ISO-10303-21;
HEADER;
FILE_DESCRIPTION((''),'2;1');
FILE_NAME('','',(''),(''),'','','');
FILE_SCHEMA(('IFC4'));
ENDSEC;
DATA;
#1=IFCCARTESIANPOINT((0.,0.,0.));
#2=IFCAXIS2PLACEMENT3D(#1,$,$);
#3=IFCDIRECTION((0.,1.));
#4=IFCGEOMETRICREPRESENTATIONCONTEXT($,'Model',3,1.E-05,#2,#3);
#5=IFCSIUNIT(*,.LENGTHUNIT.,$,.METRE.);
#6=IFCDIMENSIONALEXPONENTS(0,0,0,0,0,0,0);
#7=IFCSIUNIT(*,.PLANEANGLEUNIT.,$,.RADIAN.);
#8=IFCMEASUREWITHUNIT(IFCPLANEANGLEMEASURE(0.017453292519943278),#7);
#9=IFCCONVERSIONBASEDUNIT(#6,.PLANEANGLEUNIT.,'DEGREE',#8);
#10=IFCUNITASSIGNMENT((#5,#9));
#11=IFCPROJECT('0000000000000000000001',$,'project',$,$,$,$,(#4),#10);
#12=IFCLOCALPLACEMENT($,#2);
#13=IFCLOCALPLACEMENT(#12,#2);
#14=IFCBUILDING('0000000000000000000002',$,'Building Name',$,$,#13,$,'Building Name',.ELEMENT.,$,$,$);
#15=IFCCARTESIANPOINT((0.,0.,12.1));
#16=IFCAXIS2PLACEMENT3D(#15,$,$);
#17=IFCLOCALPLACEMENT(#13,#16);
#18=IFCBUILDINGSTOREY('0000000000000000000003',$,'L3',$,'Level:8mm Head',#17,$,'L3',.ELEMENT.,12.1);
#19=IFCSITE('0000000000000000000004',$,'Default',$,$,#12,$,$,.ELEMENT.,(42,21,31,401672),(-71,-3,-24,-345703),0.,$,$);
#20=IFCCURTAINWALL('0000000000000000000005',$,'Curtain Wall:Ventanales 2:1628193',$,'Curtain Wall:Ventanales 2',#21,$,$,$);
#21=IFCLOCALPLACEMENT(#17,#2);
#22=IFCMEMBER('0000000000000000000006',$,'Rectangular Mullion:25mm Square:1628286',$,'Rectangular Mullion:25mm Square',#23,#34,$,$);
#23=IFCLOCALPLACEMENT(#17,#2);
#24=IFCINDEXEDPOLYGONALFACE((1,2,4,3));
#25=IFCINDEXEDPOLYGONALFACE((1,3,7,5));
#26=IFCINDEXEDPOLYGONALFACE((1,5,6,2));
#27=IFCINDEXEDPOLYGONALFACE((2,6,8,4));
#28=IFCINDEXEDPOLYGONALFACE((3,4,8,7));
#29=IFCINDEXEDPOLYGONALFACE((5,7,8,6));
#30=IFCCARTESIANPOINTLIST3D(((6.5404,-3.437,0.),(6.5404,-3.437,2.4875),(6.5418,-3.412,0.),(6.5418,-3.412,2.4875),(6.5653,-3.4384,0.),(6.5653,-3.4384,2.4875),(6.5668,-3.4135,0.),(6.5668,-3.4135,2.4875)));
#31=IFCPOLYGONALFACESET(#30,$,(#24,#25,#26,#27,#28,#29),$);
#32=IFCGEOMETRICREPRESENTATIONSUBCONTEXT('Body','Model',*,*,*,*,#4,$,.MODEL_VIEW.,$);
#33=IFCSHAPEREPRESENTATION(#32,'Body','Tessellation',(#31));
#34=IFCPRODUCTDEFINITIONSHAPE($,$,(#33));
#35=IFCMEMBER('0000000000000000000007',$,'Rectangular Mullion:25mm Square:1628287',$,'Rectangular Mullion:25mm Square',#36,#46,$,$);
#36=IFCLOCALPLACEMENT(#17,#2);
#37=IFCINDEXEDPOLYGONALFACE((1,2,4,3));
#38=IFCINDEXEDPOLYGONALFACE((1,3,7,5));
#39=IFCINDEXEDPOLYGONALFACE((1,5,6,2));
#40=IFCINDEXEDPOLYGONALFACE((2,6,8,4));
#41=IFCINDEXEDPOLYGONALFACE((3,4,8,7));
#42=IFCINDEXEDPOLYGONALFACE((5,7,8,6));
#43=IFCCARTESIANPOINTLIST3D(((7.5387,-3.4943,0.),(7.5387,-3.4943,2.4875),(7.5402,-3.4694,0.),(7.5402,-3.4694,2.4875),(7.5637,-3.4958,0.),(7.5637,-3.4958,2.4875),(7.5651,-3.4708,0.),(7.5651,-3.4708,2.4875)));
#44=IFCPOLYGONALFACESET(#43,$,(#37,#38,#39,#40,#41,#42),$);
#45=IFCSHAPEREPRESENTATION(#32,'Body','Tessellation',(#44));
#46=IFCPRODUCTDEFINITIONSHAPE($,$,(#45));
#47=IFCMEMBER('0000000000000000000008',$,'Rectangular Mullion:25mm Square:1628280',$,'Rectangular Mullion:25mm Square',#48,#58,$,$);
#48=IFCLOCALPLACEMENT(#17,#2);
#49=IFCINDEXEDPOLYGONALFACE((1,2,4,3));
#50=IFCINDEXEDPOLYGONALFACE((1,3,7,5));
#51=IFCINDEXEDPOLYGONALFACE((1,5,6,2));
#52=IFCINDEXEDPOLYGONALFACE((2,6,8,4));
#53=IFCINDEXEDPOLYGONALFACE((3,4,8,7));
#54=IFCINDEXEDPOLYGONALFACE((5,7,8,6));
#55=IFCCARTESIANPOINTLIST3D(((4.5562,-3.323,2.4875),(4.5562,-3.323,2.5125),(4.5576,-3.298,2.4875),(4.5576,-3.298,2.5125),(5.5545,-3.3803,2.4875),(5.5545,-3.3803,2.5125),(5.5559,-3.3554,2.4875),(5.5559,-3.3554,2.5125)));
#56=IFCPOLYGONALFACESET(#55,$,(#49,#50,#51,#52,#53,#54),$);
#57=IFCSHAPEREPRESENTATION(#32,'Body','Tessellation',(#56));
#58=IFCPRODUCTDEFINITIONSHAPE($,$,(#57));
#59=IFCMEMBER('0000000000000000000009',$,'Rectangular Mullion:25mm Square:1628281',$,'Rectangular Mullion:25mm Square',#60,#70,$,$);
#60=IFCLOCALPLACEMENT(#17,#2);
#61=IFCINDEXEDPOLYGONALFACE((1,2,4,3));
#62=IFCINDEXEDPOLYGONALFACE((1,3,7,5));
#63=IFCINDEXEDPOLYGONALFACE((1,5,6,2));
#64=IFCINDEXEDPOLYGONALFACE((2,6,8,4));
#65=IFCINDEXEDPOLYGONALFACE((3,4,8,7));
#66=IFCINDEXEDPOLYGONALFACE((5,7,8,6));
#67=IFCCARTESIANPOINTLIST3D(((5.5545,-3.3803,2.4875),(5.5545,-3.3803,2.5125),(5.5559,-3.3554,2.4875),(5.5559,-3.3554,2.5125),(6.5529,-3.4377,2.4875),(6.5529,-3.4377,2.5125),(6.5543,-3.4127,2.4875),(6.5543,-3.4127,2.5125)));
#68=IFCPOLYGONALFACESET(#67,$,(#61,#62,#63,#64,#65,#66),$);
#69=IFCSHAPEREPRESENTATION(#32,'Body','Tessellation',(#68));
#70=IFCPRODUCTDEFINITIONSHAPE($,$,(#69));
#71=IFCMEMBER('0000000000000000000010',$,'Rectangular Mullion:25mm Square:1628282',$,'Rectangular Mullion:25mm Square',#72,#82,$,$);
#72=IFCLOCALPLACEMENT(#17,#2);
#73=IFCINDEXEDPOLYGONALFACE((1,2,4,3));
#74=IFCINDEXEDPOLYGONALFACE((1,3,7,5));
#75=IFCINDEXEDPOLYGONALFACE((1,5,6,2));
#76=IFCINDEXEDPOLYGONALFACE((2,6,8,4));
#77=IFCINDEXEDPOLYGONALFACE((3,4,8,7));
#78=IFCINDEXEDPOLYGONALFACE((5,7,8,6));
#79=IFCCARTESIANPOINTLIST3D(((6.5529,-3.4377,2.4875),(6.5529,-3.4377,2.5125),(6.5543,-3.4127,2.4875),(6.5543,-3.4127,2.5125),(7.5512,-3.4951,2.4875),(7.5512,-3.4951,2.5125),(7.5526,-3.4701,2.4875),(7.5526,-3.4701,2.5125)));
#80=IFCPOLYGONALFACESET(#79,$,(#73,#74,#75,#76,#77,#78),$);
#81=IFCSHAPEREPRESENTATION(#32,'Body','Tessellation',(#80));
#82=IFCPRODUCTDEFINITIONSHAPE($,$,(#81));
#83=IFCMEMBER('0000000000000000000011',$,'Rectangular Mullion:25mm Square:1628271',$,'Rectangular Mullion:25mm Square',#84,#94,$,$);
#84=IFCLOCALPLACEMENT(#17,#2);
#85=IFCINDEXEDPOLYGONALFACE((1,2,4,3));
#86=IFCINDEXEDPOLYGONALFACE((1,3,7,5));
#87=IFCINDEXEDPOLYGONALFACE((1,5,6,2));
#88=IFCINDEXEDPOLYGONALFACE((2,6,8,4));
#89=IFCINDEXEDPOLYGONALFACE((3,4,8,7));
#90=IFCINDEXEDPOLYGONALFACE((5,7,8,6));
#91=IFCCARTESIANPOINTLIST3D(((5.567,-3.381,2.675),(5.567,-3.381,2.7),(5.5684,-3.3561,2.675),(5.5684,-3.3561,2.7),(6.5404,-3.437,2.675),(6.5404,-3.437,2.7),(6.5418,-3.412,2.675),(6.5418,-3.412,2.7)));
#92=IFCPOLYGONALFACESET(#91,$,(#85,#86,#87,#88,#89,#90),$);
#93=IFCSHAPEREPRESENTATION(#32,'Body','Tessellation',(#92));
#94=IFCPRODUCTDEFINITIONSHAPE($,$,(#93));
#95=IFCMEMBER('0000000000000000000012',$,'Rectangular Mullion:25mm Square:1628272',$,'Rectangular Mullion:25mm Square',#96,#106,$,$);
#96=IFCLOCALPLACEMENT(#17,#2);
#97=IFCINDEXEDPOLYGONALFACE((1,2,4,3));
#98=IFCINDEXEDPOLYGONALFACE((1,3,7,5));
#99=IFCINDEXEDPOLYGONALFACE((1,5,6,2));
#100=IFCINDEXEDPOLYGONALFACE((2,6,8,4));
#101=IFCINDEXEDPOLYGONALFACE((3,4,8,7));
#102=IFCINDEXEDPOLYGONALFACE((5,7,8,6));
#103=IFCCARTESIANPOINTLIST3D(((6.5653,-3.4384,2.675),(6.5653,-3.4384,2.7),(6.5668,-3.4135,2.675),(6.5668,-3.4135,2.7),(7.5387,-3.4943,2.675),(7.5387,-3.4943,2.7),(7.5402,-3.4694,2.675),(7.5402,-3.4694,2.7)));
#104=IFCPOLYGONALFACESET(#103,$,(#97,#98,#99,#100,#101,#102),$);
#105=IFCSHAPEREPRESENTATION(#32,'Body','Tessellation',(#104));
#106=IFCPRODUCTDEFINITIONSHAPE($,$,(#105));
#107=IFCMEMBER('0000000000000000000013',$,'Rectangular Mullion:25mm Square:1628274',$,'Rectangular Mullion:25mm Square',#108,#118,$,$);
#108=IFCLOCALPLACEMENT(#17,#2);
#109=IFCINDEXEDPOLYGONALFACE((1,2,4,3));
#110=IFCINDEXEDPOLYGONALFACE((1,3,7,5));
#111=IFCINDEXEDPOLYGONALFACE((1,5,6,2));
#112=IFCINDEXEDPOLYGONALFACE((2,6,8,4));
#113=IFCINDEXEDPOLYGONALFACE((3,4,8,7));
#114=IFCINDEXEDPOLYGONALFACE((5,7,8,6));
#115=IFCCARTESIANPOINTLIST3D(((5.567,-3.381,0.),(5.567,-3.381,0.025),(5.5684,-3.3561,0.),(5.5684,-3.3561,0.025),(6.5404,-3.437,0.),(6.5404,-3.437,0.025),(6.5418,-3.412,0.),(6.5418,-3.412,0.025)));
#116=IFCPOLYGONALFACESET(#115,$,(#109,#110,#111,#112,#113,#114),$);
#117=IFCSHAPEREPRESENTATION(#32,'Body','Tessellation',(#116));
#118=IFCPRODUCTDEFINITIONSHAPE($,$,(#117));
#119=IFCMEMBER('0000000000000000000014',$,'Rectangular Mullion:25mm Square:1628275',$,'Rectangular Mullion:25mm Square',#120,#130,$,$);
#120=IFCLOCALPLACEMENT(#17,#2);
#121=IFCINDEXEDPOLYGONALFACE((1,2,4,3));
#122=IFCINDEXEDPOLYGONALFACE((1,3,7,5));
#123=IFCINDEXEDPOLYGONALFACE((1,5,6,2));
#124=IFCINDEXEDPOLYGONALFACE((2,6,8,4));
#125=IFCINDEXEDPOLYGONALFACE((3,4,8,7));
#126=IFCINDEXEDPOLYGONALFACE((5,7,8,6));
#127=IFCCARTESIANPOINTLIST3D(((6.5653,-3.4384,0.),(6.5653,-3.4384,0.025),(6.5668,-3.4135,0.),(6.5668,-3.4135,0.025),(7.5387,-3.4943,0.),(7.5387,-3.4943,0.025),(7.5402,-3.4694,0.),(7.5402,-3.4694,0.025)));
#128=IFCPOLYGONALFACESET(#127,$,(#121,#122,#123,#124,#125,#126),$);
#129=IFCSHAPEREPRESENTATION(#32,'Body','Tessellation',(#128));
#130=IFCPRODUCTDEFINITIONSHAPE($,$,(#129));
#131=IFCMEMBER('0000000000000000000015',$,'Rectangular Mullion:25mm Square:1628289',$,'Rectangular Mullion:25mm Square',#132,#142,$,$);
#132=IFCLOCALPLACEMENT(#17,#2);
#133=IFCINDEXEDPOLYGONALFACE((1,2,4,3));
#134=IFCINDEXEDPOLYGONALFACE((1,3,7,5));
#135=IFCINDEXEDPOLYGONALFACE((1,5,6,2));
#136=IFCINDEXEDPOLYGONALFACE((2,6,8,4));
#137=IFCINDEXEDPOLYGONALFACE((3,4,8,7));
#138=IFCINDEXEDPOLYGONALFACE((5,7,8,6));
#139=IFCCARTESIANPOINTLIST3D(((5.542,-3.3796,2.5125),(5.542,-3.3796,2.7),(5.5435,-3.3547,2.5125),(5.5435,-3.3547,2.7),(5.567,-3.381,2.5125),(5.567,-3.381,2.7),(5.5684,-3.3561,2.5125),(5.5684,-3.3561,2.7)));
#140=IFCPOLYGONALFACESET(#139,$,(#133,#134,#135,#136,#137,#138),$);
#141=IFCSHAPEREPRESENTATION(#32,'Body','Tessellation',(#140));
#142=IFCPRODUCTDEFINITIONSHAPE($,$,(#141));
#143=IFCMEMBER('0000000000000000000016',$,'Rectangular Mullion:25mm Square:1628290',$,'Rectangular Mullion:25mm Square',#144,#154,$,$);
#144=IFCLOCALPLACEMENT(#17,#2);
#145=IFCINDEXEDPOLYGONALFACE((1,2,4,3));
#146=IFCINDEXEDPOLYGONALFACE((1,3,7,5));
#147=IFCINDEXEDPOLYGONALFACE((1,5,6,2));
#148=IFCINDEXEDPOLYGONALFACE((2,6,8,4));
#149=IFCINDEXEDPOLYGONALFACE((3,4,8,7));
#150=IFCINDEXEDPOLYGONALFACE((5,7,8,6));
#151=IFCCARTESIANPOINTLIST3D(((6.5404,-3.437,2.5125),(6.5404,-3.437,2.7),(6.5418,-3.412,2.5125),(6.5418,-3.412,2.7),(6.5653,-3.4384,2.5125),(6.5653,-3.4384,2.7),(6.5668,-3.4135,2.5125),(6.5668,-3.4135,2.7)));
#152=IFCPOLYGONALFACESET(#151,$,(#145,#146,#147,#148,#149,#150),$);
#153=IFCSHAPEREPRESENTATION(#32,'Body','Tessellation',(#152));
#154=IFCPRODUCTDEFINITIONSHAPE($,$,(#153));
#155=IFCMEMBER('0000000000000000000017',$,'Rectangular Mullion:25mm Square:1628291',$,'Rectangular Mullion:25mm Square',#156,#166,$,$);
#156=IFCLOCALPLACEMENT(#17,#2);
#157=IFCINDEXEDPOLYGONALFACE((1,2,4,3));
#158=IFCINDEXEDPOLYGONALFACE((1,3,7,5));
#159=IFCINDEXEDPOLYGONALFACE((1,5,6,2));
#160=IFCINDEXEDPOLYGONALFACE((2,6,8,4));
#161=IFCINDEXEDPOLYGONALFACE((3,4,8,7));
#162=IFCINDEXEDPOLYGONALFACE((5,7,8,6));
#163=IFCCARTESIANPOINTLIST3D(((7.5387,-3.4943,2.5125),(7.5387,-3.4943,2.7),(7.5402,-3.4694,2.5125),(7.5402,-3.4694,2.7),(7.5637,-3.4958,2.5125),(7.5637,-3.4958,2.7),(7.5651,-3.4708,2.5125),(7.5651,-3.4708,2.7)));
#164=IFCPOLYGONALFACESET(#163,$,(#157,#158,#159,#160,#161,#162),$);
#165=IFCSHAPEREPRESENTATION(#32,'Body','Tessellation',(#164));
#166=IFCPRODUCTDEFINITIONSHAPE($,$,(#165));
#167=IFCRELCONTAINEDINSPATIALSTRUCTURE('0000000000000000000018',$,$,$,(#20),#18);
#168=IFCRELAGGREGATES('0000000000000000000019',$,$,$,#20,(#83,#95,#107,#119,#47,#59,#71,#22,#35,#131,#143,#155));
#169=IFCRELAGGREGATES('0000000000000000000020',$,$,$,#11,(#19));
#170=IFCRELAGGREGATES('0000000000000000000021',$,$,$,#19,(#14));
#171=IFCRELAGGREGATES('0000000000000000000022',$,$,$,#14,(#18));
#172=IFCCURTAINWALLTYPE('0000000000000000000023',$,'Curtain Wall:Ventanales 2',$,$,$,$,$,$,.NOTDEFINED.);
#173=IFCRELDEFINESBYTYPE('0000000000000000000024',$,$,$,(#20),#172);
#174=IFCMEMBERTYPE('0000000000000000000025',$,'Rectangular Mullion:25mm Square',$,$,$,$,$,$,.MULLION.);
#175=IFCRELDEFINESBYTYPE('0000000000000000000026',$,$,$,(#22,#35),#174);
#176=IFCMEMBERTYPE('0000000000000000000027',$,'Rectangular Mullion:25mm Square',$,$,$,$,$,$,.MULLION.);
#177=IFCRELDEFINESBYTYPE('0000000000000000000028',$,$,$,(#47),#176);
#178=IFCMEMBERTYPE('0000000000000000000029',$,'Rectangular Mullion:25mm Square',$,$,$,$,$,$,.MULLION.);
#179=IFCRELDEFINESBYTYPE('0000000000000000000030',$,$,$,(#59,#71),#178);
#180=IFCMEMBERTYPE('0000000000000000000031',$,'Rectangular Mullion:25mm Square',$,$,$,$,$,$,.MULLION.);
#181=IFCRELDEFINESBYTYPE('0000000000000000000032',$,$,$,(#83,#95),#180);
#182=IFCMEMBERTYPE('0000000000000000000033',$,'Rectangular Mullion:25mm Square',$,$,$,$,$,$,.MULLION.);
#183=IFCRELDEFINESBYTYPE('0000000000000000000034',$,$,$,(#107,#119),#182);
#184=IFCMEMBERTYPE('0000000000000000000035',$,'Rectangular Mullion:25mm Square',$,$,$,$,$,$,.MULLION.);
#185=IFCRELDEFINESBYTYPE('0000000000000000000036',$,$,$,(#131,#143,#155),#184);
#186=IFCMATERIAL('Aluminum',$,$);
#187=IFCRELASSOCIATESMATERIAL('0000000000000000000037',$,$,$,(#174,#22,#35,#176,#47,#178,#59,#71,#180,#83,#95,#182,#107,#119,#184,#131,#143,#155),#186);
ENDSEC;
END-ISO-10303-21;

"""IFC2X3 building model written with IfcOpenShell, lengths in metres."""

from ifc_helpers import new_model, entity, si_unit, converted_unit, direction, frame, frame_2d, origin, origin_2d_with_axis, place, context, subcontext, project, spatial, rectangle, extrude, source, transform, mapped, material, type_object, type_shapes, element, aggregate, save


model = new_model("IFC2X3")

# Units and contexts
model_context = context("Model", 3, precision=1e-05, world=origin(), true_north=direction((0.0, 1.0)))
body_context = subcontext(model_context, "Body", "Model", "MODEL_VIEW")
ifc_project = project(units=[si_unit("LENGTHUNIT", "METRE"), converted_unit("PLANEANGLEUNIT", "DEGREE", entity("IfcPlaneAngleMeasure", 0.017453292519943278), si_unit("PLANEANGLEUNIT", "RADIAN"), dimensions=[0, 0, 0, 0, 0, 0, 0])], contexts=[model_context])

# Site, building, storey
site_placement = place(None, origin())
site = spatial("IfcSite", under=ifc_project, at=site_placement, Name="Default", CompositionType="ELEMENT", RefLatitude=(42, 21, 31, 401672), RefLongitude=(-71, -3, -24, -345703), RefElevation=0.0)
building_placement = place(site_placement, origin())
building = spatial("IfcBuilding", under=site, at=building_placement, Name="Building Name", LongName="Building Name", CompositionType="ELEMENT")
storey_placement = place(building_placement, frame((0.0, 0.0, 12.1)))
storey = spatial("IfcBuildingStorey", under=building, at=storey_placement, Name="L3", ObjectType="Level:8mm Head", LongName="L3", CompositionType="ELEMENT", Elevation=12.1)

# Curtain wall, members
curtain_wall_type = type_object("IfcCurtainWallType", Name="Curtain Wall:Ventanales 2", PredefinedType="NOTDEFINED")
curtain_wall_placement = place(storey_placement, frame((0.0, 0.0, -12.1)))
curtain_wall = element("IfcCurtainWall", 1, at=curtain_wall_placement, inside=storey, type_object=curtain_wall_type, Name="Curtain Wall:Ventanales 2:1628193", ObjectType="Curtain Wall:Ventanales 2")
ifc_material_1 = material(Name="Aluminum")
member_type_1 = type_object("IfcMemberType", Name="Rectangular Mullion:25mm Square", PredefinedType="MULLION", material=ifc_material_1)
shared_shape_1 = source(origin(), body_context, "Body", "SweptSolid", [
    extrude(rectangle(XDim=0.025, YDim=0.025, at=origin_2d_with_axis()), frame((0.0, 0.0, -2.4875), z_axis=(0.0, 0.0, 1.0), x_axis=(-1.0, 0.0, 0.0)), (0.0, 0.0, 1.0), 2.4875),
])
type_shapes(member_type_1, [shared_shape_1])
member_1_placement = place(curtain_wall_placement, frame((6.5536, -3.4252, 12.1), z_axis=(0.0, 0.0, -1.0), x_axis=(0.998353, -0.057365, 0.0)))
member_1 = element("IfcMember", 2, at=member_1_placement, type_object=member_type_1, material=ifc_material_1, Name="Rectangular Mullion:25mm Square:1628286", ObjectType="Rectangular Mullion:25mm Square", context=body_context, shape_type="MappedRepresentation", body=[
    mapped(shared_shape_1, transform((0.0, 0.0, 0.0), scale=1.0)),
])
member_2_placement = place(curtain_wall_placement, frame((7.5519, -3.4826, 12.1), z_axis=(0.0, 0.0, -1.0), x_axis=(0.998353, -0.057365, 0.0)))
member_2 = element("IfcMember", 3, at=member_2_placement, type_object=member_type_1, material=ifc_material_1, Name="Rectangular Mullion:25mm Square:1628287", ObjectType="Rectangular Mullion:25mm Square", context=body_context, shape_type="MappedRepresentation", body=[
    mapped(shared_shape_1, transform((0.0, 0.0, 0.0), scale=1.0)),
])
member_type_2 = type_object("IfcMemberType", Name="Rectangular Mullion:25mm Square", PredefinedType="MULLION", material=ifc_material_1)
shared_shape_2 = source(origin(), body_context, "Body", "SweptSolid", [
    extrude(rectangle(XDim=0.025, YDim=0.025, at=frame_2d((0.0, 0.0), x_axis=(1.0, 0.0))), frame((0.0, 0.0, -1.0), z_axis=(0.0, 0.0, 1.0), x_axis=(-1.0, 0.0, 0.0)), (0.0, 0.0, 1.0), 1.0),
])
type_shapes(member_type_2, [shared_shape_2])
member_3_placement = place(curtain_wall_placement, frame((5.5552, -3.3679, 14.6), z_axis=(0.998353, -0.057365, 0.0), x_axis=(0.0, 0.0, 1.0)))
member_3 = element("IfcMember", 4, at=member_3_placement, type_object=member_type_2, material=ifc_material_1, Name="Rectangular Mullion:25mm Square:1628280", ObjectType="Rectangular Mullion:25mm Square", context=body_context, shape_type="MappedRepresentation", body=[
    mapped(shared_shape_2, transform((0.0, 0.0, 0.0), scale=1.0)),
])
member_type_3 = type_object("IfcMemberType", Name="Rectangular Mullion:25mm Square", PredefinedType="MULLION", material=ifc_material_1)
shared_shape_3 = source(origin(), body_context, "Body", "SweptSolid", [
    extrude(rectangle(XDim=0.025, YDim=0.025, at=frame_2d((0.0, 0.0), x_axis=(1.0, 0.0))), frame((0.0, 0.0, -1.0), z_axis=(0.0, 0.0, 1.0), x_axis=(-1.0, 0.0, 0.0)), (0.0, 0.0, 1.0), 1.0),
])
type_shapes(member_type_3, [shared_shape_3])
member_4_placement = place(curtain_wall_placement, frame((6.5536, -3.4252, 14.6), z_axis=(0.998353, -0.057365, 0.0), x_axis=(0.0, 0.0, 1.0)))
member_4 = element("IfcMember", 5, at=member_4_placement, type_object=member_type_3, material=ifc_material_1, Name="Rectangular Mullion:25mm Square:1628281", ObjectType="Rectangular Mullion:25mm Square", context=body_context, shape_type="MappedRepresentation", body=[
    mapped(shared_shape_3, transform((0.0, 0.0, 0.0), scale=1.0)),
])
member_5_placement = place(curtain_wall_placement, frame((7.5519, -3.4826, 14.6), z_axis=(0.998353, -0.057365, 0.0), x_axis=(0.0, 0.0, 1.0)))
member_5 = element("IfcMember", 6, at=member_5_placement, type_object=member_type_3, material=ifc_material_1, Name="Rectangular Mullion:25mm Square:1628282", ObjectType="Rectangular Mullion:25mm Square", context=body_context, shape_type="MappedRepresentation", body=[
    mapped(shared_shape_3, transform((0.0, 0.0, 0.0), scale=1.0)),
])
member_type_4 = type_object("IfcMemberType", Name="Rectangular Mullion:25mm Square", PredefinedType="MULLION", material=ifc_material_1)
shared_shape_4 = source(origin(), body_context, "Body", "SweptSolid", [
    extrude(rectangle(XDim=0.025, YDim=0.025, at=origin_2d_with_axis()), frame((-0.0125, 0.0, -0.975), z_axis=(0.0, 0.0, 1.0), x_axis=(-1.0, 0.0, 0.0)), (0.0, 0.0, 1.0), 0.975),
])
type_shapes(member_type_4, [shared_shape_4])
member_6_placement = place(curtain_wall_placement, frame((6.5411, -3.4245, 14.8), z_axis=(0.998353, -0.057365, 0.0), x_axis=(0.0, 0.0, 1.0)))
member_6 = element("IfcMember", 7, at=member_6_placement, type_object=member_type_4, material=ifc_material_1, Name="Rectangular Mullion:25mm Square:1628271", ObjectType="Rectangular Mullion:25mm Square", context=body_context, shape_type="MappedRepresentation", body=[
    mapped(shared_shape_4, transform((0.0, 0.0, 0.0), scale=1.0)),
])
member_7_placement = place(curtain_wall_placement, frame((7.5395, -3.4819, 14.8), z_axis=(0.998353, -0.057365, 0.0), x_axis=(0.0, 0.0, 1.0)))
member_7 = element("IfcMember", 8, at=member_7_placement, type_object=member_type_4, material=ifc_material_1, Name="Rectangular Mullion:25mm Square:1628272", ObjectType="Rectangular Mullion:25mm Square", context=body_context, shape_type="MappedRepresentation", body=[
    mapped(shared_shape_4, transform((0.0, 0.0, 0.0), scale=1.0)),
])
member_type_5 = type_object("IfcMemberType", Name="Rectangular Mullion:25mm Square", PredefinedType="MULLION", material=ifc_material_1)
shared_shape_5 = source(origin(), body_context, "Body", "SweptSolid", [
    extrude(rectangle(XDim=0.025, YDim=0.025, at=origin_2d_with_axis()), frame((-0.0125, 0.0, -0.975), z_axis=(0.0, 0.0, 1.0), x_axis=(-1.0, 0.0, 0.0)), (0.0, 0.0, 1.0), 0.975),
])
type_shapes(member_type_5, [shared_shape_5])
member_8_placement = place(curtain_wall_placement, frame((5.5677, -3.3686, 12.1), z_axis=(-0.998353, 0.057365, 0.0), x_axis=(0.0, 0.0, -1.0)))
member_8 = element("IfcMember", 9, at=member_8_placement, type_object=member_type_5, material=ifc_material_1, Name="Rectangular Mullion:25mm Square:1628274", ObjectType="Rectangular Mullion:25mm Square", context=body_context, shape_type="MappedRepresentation", body=[
    mapped(shared_shape_5, transform((0.0, 0.0, 0.0), scale=1.0)),
])
member_9_placement = place(curtain_wall_placement, frame((6.5661, -3.4259, 12.1), z_axis=(-0.998353, 0.057365, 0.0), x_axis=(0.0, 0.0, -1.0)))
member_9 = element("IfcMember", 10, at=member_9_placement, type_object=member_type_5, material=ifc_material_1, Name="Rectangular Mullion:25mm Square:1628275", ObjectType="Rectangular Mullion:25mm Square", context=body_context, shape_type="MappedRepresentation", body=[
    mapped(shared_shape_5, transform((0.0, 0.0, 0.0), scale=1.0)),
])
member_type_6 = type_object("IfcMemberType", Name="Rectangular Mullion:25mm Square", PredefinedType="MULLION", material=ifc_material_1)
shared_shape_6 = source(origin(), body_context, "Body", "SweptSolid", [
    extrude(rectangle(XDim=0.025, YDim=0.025, at=frame_2d((0.0, 0.0), x_axis=(1.0, 0.0))), frame((0.0, 0.0, -0.1875), z_axis=(0.0, 0.0, 1.0), x_axis=(-1.0, 0.0, 0.0)), (0.0, 0.0, 1.0), 0.1875),
])
type_shapes(member_type_6, [shared_shape_6])
member_10_placement = place(curtain_wall_placement, frame((5.5552, -3.3679, 14.6125), z_axis=(0.0, 0.0, -1.0), x_axis=(0.998353, -0.057365, 0.0)))
member_10 = element("IfcMember", 11, at=member_10_placement, type_object=member_type_6, material=ifc_material_1, Name="Rectangular Mullion:25mm Square:1628289", ObjectType="Rectangular Mullion:25mm Square", context=body_context, shape_type="MappedRepresentation", body=[
    mapped(shared_shape_6, transform((0.0, 0.0, 0.0), scale=1.0)),
])
member_11_placement = place(curtain_wall_placement, frame((6.5536, -3.4252, 14.6125), z_axis=(0.0, 0.0, -1.0), x_axis=(0.998353, -0.057365, 0.0)))
member_11 = element("IfcMember", 12, at=member_11_placement, type_object=member_type_6, material=ifc_material_1, Name="Rectangular Mullion:25mm Square:1628290", ObjectType="Rectangular Mullion:25mm Square", context=body_context, shape_type="MappedRepresentation", body=[
    mapped(shared_shape_6, transform((0.0, 0.0, 0.0), scale=1.0)),
])
member_12_placement = place(curtain_wall_placement, frame((7.5519, -3.4826, 14.6125), z_axis=(0.0, 0.0, -1.0), x_axis=(0.998353, -0.057365, 0.0)))
member_12 = element("IfcMember", 13, at=member_12_placement, type_object=member_type_6, material=ifc_material_1, Name="Rectangular Mullion:25mm Square:1628291", ObjectType="Rectangular Mullion:25mm Square", context=body_context, shape_type="MappedRepresentation", body=[
    mapped(shared_shape_6, transform((0.0, 0.0, 0.0), scale=1.0)),
])
aggregate(curtain_wall, [member_6, member_7, member_8, member_9, member_3, member_4, member_5, member_1, member_2, member_10, member_11, member_12])

save(model, "model.ifc")
